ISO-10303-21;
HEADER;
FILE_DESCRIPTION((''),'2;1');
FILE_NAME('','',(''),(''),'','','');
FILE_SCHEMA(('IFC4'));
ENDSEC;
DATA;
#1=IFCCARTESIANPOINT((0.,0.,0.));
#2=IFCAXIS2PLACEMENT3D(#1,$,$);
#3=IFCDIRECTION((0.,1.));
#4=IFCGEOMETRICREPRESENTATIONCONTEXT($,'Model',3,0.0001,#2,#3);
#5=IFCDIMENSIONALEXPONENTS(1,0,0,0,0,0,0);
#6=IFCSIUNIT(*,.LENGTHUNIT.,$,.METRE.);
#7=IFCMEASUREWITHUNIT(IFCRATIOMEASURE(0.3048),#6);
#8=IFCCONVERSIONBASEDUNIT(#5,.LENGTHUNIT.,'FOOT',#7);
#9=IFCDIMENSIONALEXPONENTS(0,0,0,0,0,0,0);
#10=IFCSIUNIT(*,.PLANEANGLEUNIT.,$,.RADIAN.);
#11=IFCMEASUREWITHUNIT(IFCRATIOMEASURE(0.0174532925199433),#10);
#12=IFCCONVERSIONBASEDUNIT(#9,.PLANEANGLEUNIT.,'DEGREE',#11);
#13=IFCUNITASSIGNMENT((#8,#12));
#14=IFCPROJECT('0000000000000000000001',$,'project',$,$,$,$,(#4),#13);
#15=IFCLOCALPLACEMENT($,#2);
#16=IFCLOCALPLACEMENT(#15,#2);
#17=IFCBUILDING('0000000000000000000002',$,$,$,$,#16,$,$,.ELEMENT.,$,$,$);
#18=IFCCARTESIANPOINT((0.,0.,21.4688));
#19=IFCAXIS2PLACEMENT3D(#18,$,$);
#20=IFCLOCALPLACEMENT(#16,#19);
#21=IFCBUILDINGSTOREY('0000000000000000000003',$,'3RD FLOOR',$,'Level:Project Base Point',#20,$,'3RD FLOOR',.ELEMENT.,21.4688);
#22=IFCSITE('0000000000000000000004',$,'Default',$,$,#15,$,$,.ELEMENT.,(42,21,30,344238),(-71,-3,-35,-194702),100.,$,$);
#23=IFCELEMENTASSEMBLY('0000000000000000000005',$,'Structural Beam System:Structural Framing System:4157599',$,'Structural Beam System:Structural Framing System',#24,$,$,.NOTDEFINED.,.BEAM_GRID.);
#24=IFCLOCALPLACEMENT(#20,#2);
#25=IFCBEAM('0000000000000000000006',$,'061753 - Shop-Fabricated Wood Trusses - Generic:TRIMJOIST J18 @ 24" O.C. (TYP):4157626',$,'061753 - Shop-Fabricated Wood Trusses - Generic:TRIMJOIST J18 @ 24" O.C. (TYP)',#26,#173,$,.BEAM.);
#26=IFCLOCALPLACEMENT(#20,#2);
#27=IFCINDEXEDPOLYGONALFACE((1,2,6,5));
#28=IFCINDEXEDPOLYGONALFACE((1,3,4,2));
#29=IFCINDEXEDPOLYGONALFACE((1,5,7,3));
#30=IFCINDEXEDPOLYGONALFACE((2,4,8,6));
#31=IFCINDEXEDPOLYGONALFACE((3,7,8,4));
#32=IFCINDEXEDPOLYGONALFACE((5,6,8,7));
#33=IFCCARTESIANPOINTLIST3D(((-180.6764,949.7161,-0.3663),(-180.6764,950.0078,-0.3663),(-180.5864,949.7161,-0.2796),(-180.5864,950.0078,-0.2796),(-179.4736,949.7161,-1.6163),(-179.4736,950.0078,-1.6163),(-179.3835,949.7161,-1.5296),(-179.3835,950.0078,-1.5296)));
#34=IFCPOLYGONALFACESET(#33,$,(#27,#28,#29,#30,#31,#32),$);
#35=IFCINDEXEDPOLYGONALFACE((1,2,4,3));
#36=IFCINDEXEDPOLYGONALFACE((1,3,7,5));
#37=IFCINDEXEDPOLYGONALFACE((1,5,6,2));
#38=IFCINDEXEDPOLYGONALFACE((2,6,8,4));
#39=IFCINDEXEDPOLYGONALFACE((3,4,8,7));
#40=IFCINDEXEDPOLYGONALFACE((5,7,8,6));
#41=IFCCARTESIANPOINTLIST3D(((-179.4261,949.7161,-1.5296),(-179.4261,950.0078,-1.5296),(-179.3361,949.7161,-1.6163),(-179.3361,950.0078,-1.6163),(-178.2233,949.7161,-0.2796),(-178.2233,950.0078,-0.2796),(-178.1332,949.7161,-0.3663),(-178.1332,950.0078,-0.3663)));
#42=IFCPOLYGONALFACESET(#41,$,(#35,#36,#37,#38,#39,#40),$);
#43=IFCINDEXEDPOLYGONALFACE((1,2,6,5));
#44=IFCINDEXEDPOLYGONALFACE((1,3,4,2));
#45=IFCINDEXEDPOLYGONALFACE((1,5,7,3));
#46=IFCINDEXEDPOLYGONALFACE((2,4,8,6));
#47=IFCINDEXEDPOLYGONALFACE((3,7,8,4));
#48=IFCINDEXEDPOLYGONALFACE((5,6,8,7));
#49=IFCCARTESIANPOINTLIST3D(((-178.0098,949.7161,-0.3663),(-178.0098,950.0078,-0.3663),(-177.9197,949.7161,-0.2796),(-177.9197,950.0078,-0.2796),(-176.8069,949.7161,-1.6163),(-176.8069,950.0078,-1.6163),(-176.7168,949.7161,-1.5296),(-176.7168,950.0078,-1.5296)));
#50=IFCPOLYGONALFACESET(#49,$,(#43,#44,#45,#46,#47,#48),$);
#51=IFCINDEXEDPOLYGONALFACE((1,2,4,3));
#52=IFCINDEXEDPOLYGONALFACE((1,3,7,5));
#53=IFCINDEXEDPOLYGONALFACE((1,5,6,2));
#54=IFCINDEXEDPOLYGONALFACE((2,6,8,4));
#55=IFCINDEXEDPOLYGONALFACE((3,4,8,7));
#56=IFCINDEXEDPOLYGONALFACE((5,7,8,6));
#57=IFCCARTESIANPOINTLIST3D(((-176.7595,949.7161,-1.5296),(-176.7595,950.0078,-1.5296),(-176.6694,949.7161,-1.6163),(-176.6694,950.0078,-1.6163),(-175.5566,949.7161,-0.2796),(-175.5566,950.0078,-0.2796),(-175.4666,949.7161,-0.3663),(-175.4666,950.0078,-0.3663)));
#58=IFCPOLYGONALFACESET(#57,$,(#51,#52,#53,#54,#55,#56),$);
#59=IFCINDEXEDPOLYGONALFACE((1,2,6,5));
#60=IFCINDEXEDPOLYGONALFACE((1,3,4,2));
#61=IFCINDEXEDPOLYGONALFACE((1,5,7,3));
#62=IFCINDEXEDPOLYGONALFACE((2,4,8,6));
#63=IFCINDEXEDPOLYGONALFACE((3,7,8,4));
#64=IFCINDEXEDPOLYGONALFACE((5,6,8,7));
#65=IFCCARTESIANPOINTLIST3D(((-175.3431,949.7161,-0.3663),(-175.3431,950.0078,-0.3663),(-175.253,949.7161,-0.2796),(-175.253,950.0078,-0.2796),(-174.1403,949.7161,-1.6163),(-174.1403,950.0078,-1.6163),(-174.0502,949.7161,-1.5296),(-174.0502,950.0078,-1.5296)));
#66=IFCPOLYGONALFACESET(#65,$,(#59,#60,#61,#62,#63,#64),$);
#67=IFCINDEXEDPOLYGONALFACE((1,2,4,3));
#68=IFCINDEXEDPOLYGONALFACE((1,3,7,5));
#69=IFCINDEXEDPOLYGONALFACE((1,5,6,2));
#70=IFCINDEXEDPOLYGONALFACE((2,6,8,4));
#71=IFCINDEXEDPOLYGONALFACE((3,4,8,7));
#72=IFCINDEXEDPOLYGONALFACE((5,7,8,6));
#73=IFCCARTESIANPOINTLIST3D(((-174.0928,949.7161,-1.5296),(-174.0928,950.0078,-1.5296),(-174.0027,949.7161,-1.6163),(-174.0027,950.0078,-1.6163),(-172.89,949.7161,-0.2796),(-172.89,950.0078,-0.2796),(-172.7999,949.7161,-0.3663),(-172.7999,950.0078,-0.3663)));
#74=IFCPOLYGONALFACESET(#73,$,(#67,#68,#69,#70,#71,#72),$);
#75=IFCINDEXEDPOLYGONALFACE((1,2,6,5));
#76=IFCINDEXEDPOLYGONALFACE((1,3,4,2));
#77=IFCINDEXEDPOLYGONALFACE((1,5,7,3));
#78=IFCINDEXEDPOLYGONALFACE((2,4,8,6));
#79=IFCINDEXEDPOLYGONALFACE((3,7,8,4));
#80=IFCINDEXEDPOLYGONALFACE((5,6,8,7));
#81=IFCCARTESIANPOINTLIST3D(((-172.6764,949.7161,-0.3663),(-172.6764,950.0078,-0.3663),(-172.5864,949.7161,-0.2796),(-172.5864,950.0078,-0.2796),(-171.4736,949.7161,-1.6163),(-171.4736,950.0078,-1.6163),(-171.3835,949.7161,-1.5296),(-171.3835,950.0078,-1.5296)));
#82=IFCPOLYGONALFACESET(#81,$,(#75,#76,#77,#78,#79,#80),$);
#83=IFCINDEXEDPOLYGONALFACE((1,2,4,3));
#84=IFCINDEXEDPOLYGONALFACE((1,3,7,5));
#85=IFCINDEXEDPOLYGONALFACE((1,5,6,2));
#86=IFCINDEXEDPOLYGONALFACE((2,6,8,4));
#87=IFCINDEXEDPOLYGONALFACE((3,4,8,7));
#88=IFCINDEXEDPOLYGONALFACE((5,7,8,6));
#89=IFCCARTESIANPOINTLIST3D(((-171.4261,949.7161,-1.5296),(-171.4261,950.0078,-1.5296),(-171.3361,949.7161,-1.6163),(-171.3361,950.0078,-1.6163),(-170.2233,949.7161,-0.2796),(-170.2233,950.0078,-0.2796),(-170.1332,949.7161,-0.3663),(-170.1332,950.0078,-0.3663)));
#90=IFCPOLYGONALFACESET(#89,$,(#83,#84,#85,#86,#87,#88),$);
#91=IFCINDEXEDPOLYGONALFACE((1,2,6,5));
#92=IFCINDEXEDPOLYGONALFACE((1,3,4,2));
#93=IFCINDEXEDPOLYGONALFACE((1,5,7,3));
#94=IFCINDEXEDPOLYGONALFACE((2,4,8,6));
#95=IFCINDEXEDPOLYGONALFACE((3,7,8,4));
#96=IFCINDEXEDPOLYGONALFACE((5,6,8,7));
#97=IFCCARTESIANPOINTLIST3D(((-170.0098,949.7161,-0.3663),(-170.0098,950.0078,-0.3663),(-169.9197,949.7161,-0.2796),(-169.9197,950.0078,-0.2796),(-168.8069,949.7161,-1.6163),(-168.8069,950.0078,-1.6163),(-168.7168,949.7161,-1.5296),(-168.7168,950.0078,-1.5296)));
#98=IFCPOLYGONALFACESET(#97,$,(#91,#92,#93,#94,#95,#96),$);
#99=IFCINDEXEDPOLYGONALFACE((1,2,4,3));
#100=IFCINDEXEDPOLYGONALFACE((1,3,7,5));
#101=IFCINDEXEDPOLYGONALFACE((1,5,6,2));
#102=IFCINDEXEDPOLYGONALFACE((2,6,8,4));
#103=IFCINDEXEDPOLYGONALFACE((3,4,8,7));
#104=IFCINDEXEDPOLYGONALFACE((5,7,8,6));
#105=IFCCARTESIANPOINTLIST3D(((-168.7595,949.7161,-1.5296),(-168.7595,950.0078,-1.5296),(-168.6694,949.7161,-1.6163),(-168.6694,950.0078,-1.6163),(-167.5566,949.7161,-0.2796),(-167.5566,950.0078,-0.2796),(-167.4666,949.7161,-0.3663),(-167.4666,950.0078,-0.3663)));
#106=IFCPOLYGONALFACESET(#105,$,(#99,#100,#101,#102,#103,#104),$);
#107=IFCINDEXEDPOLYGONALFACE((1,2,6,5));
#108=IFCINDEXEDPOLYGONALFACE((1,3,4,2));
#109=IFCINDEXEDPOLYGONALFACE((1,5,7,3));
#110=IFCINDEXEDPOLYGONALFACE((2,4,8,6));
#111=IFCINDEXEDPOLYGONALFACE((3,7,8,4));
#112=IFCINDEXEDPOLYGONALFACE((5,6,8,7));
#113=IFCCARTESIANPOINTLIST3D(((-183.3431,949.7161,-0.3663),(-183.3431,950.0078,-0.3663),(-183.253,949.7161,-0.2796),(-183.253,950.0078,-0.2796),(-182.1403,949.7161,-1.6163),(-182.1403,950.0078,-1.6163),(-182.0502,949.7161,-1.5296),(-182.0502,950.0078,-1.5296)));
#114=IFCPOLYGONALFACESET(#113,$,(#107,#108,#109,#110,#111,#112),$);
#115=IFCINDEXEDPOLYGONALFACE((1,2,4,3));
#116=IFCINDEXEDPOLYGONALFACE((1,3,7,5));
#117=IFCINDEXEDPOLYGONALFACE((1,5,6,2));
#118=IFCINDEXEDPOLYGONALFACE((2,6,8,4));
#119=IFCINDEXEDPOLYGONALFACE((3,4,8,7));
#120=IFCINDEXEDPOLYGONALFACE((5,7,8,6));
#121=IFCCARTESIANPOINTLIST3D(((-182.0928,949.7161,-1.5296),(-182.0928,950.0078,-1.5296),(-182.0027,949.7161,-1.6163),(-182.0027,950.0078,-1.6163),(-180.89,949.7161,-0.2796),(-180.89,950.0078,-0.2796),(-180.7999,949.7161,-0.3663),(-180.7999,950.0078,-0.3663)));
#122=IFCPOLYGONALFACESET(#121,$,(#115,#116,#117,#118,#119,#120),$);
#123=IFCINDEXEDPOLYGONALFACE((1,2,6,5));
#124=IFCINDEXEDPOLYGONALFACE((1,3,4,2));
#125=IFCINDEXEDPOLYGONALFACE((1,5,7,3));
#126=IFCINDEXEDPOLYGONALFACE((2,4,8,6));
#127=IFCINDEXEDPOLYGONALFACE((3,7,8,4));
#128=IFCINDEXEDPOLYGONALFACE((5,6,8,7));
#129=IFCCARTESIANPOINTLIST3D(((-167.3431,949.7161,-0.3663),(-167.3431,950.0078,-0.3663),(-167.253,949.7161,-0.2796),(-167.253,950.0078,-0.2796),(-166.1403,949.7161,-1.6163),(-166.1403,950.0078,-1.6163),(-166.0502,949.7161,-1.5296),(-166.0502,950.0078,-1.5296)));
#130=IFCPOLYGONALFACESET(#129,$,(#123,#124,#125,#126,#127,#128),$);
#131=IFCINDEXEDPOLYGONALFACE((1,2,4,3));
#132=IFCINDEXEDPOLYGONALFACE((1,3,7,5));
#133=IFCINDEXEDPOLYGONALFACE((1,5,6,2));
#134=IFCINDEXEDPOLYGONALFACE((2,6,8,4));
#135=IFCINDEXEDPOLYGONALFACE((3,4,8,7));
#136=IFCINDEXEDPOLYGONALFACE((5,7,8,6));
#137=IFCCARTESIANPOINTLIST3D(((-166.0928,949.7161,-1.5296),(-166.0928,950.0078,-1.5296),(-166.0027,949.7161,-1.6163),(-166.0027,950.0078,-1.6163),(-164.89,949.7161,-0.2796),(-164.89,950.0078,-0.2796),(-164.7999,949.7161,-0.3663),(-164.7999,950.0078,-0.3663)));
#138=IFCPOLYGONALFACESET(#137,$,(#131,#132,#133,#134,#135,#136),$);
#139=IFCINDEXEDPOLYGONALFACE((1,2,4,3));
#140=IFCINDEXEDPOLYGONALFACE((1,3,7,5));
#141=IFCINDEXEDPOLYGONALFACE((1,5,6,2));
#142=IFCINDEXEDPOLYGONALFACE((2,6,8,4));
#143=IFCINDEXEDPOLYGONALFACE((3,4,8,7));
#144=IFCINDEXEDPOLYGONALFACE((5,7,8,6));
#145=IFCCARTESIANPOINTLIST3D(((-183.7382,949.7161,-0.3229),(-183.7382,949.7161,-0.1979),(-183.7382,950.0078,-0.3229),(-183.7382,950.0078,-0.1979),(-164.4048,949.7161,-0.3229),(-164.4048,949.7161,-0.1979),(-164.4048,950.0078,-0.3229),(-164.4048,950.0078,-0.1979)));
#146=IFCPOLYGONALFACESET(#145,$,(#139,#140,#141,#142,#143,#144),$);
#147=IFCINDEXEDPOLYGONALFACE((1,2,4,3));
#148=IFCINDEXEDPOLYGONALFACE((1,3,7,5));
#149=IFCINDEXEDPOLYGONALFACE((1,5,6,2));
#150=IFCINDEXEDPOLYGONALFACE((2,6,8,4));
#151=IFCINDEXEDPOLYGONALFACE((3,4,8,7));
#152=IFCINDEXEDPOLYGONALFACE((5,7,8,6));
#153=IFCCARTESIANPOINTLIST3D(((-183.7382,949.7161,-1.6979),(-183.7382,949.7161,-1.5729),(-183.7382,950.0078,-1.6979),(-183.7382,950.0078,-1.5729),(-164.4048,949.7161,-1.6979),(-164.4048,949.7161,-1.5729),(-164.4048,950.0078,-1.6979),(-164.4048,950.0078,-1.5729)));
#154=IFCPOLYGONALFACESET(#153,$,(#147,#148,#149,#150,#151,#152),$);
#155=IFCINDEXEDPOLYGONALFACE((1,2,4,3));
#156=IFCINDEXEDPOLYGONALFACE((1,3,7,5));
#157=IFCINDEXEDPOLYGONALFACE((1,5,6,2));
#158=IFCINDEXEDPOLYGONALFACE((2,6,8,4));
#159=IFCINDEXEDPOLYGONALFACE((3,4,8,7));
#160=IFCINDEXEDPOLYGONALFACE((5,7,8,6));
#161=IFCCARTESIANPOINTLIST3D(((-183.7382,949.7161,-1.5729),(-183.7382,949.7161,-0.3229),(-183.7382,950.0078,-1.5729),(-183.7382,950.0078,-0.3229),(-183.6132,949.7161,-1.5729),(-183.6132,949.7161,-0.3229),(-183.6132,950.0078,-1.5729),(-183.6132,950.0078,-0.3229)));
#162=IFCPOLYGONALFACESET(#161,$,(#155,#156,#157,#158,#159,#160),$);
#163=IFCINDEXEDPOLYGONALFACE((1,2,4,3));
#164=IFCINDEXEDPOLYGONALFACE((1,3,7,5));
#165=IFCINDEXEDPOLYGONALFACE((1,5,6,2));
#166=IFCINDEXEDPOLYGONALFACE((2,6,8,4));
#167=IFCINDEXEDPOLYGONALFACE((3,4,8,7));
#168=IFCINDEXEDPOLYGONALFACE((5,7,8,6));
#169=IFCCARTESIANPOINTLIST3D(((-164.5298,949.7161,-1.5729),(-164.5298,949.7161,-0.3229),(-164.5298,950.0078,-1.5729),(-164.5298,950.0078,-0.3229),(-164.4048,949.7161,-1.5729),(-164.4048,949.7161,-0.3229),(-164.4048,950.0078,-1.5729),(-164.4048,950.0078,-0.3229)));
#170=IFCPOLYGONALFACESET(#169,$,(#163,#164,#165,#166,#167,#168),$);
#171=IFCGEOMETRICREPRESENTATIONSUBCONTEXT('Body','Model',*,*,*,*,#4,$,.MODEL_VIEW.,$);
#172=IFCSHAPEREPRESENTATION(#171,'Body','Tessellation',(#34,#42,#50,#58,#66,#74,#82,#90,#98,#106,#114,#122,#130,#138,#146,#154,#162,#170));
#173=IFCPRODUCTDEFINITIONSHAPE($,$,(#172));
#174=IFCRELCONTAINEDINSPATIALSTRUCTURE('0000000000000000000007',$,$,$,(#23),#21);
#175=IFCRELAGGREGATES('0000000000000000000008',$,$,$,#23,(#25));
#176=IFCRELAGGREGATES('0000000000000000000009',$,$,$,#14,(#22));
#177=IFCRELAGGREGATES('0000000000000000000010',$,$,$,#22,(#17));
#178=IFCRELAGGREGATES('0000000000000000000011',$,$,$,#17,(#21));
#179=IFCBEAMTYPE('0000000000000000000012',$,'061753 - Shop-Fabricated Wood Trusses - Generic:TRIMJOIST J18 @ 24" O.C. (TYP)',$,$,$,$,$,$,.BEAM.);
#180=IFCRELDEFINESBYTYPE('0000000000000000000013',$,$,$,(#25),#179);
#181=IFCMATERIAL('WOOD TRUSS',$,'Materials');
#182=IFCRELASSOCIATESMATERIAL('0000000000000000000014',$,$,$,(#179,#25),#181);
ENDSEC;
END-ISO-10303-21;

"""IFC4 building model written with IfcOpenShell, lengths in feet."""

from ifc_helpers import new_model, entity, si_unit, converted_unit, direction, frame, frame_2d, origin, origin_2d_with_axis, place, context, subcontext, project, spatial, rectangle, extrude, source, transform, mapped, material, material_profile, profile_set, profile_usage, type_object, type_shapes, element, aggregate, save


model = new_model("IFC4")

# Units and contexts
model_context = context("Model", 3, precision=0.0001, world=origin(), true_north=direction((0.0, 1.0)))
body_context = subcontext(model_context, "Body", "Model", "MODEL_VIEW")
ifc_project = project(units=[converted_unit("LENGTHUNIT", "FOOT", entity("IfcRatioMeasure", 0.3048), si_unit("LENGTHUNIT", "METRE"), dimensions=[1, 0, 0, 0, 0, 0, 0]), converted_unit("PLANEANGLEUNIT", "DEGREE", entity("IfcRatioMeasure", 0.0174532925199433), si_unit("PLANEANGLEUNIT", "RADIAN"), dimensions=[0, 0, 0, 0, 0, 0, 0])], contexts=[model_context])

# Site, building, storey
site_placement = place(None, origin())
site = spatial("IfcSite", under=ifc_project, at=site_placement, Name="Default", CompositionType="ELEMENT", RefLatitude=(42, 21, 30, 344238), RefLongitude=(-71, -3, -35, -194702), RefElevation=100.0)
building_placement = place(site_placement, origin())
building = spatial("IfcBuilding", under=site, at=building_placement, CompositionType="ELEMENT")
storey_placement = place(building_placement, frame((0.0, 0.0, 21.4688)))
storey = spatial("IfcBuildingStorey", under=building, at=storey_placement, Name="3RD FLOOR", ObjectType="Level:Project Base Point", LongName="3RD FLOOR", CompositionType="ELEMENT", Elevation=21.4688)

# Element assembly, beam
ifc_material = material(Name="WOOD TRUSS", Category="Materials")
ifc_material_profile_1 = material_profile(ifc_material, rectangle(XDim=1.7347, YDim=0.125, at=frame_2d((0.0, 0.0), x_axis=(1.0, 0.0))), Name="TRIMJOIST J18 @ 24\" O.C. (TYP)")
ifc_material_profile_2 = material_profile(ifc_material, rectangle(XDim=1.7347, YDim=0.125, at=frame_2d((0.0, 0.0), x_axis=(1.0, 0.0))), Name="TRIMJOIST J18 @ 24\" O.C. (TYP)")
ifc_material_profile_3 = material_profile(ifc_material, rectangle(XDim=1.7347, YDim=0.125, at=frame_2d((0.0, 0.0), x_axis=(1.0, 0.0))), Name="TRIMJOIST J18 @ 24\" O.C. (TYP)")
ifc_material_profile_4 = material_profile(ifc_material, rectangle(XDim=1.7347, YDim=0.125, at=frame_2d((0.0, 0.0), x_axis=(1.0, 0.0))), Name="TRIMJOIST J18 @ 24\" O.C. (TYP)")
ifc_material_profile_5 = material_profile(ifc_material, rectangle(XDim=1.7347, YDim=0.125, at=frame_2d((0.0, 0.0), x_axis=(1.0, 0.0))), Name="TRIMJOIST J18 @ 24\" O.C. (TYP)")
ifc_material_profile_6 = material_profile(ifc_material, rectangle(XDim=1.7347, YDim=0.125, at=frame_2d((0.0, 0.0), x_axis=(1.0, 0.0))), Name="TRIMJOIST J18 @ 24\" O.C. (TYP)")
ifc_material_profile_7 = material_profile(ifc_material, rectangle(XDim=1.7347, YDim=0.125, at=frame_2d((0.0, 0.0), x_axis=(1.0, 0.0))), Name="TRIMJOIST J18 @ 24\" O.C. (TYP)")
ifc_material_profile_8 = material_profile(ifc_material, rectangle(XDim=1.7347, YDim=0.125, at=frame_2d((0.0, 0.0), x_axis=(1.0, 0.0))), Name="TRIMJOIST J18 @ 24\" O.C. (TYP)")
ifc_material_profile_9 = material_profile(ifc_material, rectangle(XDim=1.7347, YDim=0.125, at=frame_2d((0.0, 0.0), x_axis=(1.0, 0.0))), Name="TRIMJOIST J18 @ 24\" O.C. (TYP)")
ifc_material_profile_10 = material_profile(ifc_material, rectangle(XDim=1.7347, YDim=0.125, at=origin_2d_with_axis()), Name="TRIMJOIST J18 @ 24\" O.C. (TYP)")
ifc_material_profile_11 = material_profile(ifc_material, rectangle(XDim=0.125, YDim=0.2917, at=origin_2d_with_axis()), Name="TRIMJOIST J18 @ 24\" O.C. (TYP)")
ifc_material_profile_12 = material_profile(ifc_material, rectangle(XDim=0.125, YDim=0.2917, at=origin_2d_with_axis()), Name="TRIMJOIST J18 @ 24\" O.C. (TYP)")
ifc_material_profile_13 = material_profile(ifc_material, rectangle(XDim=1.25, YDim=0.2917, at=origin_2d_with_axis()), Name="TRIMJOIST J18 @ 24\" O.C. (TYP)")
ifc_material_profile_14 = material_profile(ifc_material, rectangle(XDim=1.25, YDim=0.2917, at=origin_2d_with_axis()), Name="TRIMJOIST J18 @ 24\" O.C. (TYP)")
ifc_profile_set = profile_set([ifc_material_profile_1, ifc_material_profile_2, ifc_material_profile_3, ifc_material_profile_4, ifc_material_profile_5, ifc_material_profile_6, ifc_material_profile_7, ifc_material_profile_8, ifc_material_profile_9, ifc_material_profile_10, ifc_material_profile_11, ifc_material_profile_12, ifc_material_profile_13, ifc_material_profile_14], Name="TRIMJOIST J18 @ 24\" O.C. (TYP)")
assembly_1_placement = place(storey_placement, origin())
assembly_1 = element("IfcElementAssembly", 1, at=assembly_1_placement, inside=storey, Name="Structural Beam System:Structural Framing System:4157599", ObjectType="Structural Beam System:Structural Framing System", AssemblyPlace="NOTDEFINED", PredefinedType="BEAM_GRID")
beam_type_1 = type_object("IfcBeamType", Name="061753 - Shop-Fabricated Wood Trusses - Generic:TRIMJOIST J18 @ 24\" O.C. (TYP)", PredefinedType="BEAM", material=ifc_profile_set)
shared_shape_1 = source(origin(), body_context, "Body", "SweptSolid", [
    extrude(rectangle(XDim=1.7347, YDim=0.125, at=frame_2d((0.0, 0.0), x_axis=(1.0, 0.0))), frame((5.9585, -0.1458, 0.0), z_axis=(0.0, 1.0, 0.0), x_axis=(0.693383, 0.0, 0.720569)), (0.0, 0.0, 1.0), 0.2917),
    extrude(rectangle(XDim=1.7347, YDim=0.125, at=origin_2d_with_axis()), frame((4.7082, -0.1458, 0.0), z_axis=(0.0, 1.0, 0.0), x_axis=(0.693383, 0.0, -0.720569)), (0.0, 0.0, 1.0), 0.2917),
    extrude(rectangle(XDim=1.7347, YDim=0.125, at=frame_2d((0.0, 0.0), x_axis=(1.0, 0.0))), frame((3.2918, -0.1458, 0.0), z_axis=(0.0, 1.0, 0.0), x_axis=(0.693383, 0.0, 0.720569)), (0.0, 0.0, 1.0), 0.2917),
    extrude(rectangle(XDim=1.7347, YDim=0.125, at=frame_2d((0.0, 0.0), x_axis=(1.0, 0.0))), frame((2.0415, -0.1458, 0.0), z_axis=(0.0, 1.0, 0.0), x_axis=(0.693383, 0.0, -0.720569)), (0.0, 0.0, 1.0), 0.2917),
    extrude(rectangle(XDim=1.7347, YDim=0.125, at=frame_2d((0.0, 0.0), x_axis=(1.0, 0.0))), frame((0.6251, -0.1458, 0.0), z_axis=(0.0, 1.0, 0.0), x_axis=(0.693383, 0.0, 0.720569)), (0.0, 0.0, 1.0), 0.2917),
    extrude(rectangle(XDim=1.7347, YDim=0.125, at=frame_2d((0.0, 0.0), x_axis=(1.0, 0.0))), frame((-0.6251, -0.1458, 0.0), z_axis=(0.0, 1.0, 0.0), x_axis=(0.693383, 0.0, -0.720569)), (0.0, 0.0, 1.0), 0.2917),
    extrude(rectangle(XDim=1.7347, YDim=0.125, at=frame_2d((0.0, 0.0), x_axis=(1.0, 0.0))), frame((-2.0415, -0.1458, 0.0), z_axis=(0.0, 1.0, 0.0), x_axis=(0.693383, 0.0, 0.720569)), (0.0, 0.0, 1.0), 0.2917),
    extrude(rectangle(XDim=1.7347, YDim=0.125, at=origin_2d_with_axis()), frame((-3.2918, -0.1458, 0.0), z_axis=(0.0, 1.0, 0.0), x_axis=(0.693383, 0.0, -0.720569)), (0.0, 0.0, 1.0), 0.2917),
    extrude(rectangle(XDim=1.7347, YDim=0.125, at=frame_2d((0.0, 0.0), x_axis=(1.0, 0.0))), frame((-4.7082, -0.1458, 0.0), z_axis=(0.0, 1.0, 0.0), x_axis=(0.693383, 0.0, 0.720569)), (0.0, 0.0, 1.0), 0.2917),
    extrude(rectangle(XDim=1.7347, YDim=0.125, at=frame_2d((0.0, 0.0), x_axis=(1.0, 0.0))), frame((-5.9585, -0.1458, 0.0), z_axis=(0.0, 1.0, 0.0), x_axis=(0.693383, 0.0, -0.720569)), (0.0, 0.0, 1.0), 0.2917),
    extrude(rectangle(XDim=1.7347, YDim=0.125, at=frame_2d((0.0, 0.0), x_axis=(1.0, 0.0))), frame((8.6251, -0.1458, 0.0), z_axis=(0.0, 1.0, 0.0), x_axis=(0.693383, 0.0, 0.720569)), (0.0, 0.0, 1.0), 0.2917),
    extrude(rectangle(XDim=1.7347, YDim=0.125, at=origin_2d_with_axis()), frame((7.3749, -0.1458, 0.0), z_axis=(0.0, 1.0, 0.0), x_axis=(0.693383, 0.0, -0.720569)), (0.0, 0.0, 1.0), 0.2917),
    extrude(rectangle(XDim=1.7347, YDim=0.125, at=frame_2d((0.0, 0.0), x_axis=(1.0, 0.0))), frame((-7.3749, -0.1458, 0.0), z_axis=(0.0, 1.0, 0.0), x_axis=(0.693383, 0.0, 0.720569)), (0.0, 0.0, 1.0), 0.2917),
    extrude(rectangle(XDim=1.7347, YDim=0.125, at=origin_2d_with_axis()), frame((-8.6251, -0.1458, 0.0), z_axis=(0.0, 1.0, 0.0), x_axis=(0.693383, 0.0, -0.720569)), (0.0, 0.0, 1.0), 0.2917),
    extrude(rectangle(XDim=0.125, YDim=0.2917, at=origin_2d_with_axis()), frame((-9.6667, 0.0, 0.6875), z_axis=(1.0, 0.0, 0.0), x_axis=(0.0, 0.0, -1.0)), (0.0, 0.0, 1.0), 19.3333),
    extrude(rectangle(XDim=0.125, YDim=0.2917, at=origin_2d_with_axis()), frame((-9.6667, 0.0, -0.6875), z_axis=(1.0, 0.0, 0.0), x_axis=(0.0, 0.0, -1.0)), (0.0, 0.0, 1.0), 19.3333),
    extrude(rectangle(XDim=1.25, YDim=0.2917, at=origin_2d_with_axis()), frame((9.5417, 0.0, 0.0), z_axis=(1.0, 0.0, 0.0), x_axis=(0.0, 0.0, -1.0)), (0.0, 0.0, 1.0), 0.125),
    extrude(rectangle(XDim=1.25, YDim=0.2917, at=origin_2d_with_axis()), frame((-9.6667, 0.0, 0.0), z_axis=(1.0, 0.0, 0.0), x_axis=(0.0, 0.0, -1.0)), (0.0, 0.0, 1.0), 0.125),
])
type_shapes(beam_type_1, [shared_shape_1])
ifc_profile_usage_1 = profile_usage(ifc_profile_set, cardinal=8)
beam_1_placement = place(assembly_1_placement, frame((-174.0715, 949.8619, -0.9479), z_axis=(0.0, 0.0, 1.0), x_axis=(-1.0, 0.0, 0.0)))
beam_1 = element("IfcBeam", 2, at=beam_1_placement, type_object=beam_type_1, material=ifc_profile_usage_1, Name="061753 - Shop-Fabricated Wood Trusses - Generic:TRIMJOIST J18 @ 24\" O.C. (TYP):4157626", ObjectType="061753 - Shop-Fabricated Wood Trusses - Generic:TRIMJOIST J18 @ 24\" O.C. (TYP)", PredefinedType="BEAM", context=body_context, shape_type="MappedRepresentation", body=[
    mapped(shared_shape_1, transform((0.0, 0.0, 0.0), scale=1.0)),
])
aggregate(assembly_1, [beam_1])

save(model, "model.ifc")
